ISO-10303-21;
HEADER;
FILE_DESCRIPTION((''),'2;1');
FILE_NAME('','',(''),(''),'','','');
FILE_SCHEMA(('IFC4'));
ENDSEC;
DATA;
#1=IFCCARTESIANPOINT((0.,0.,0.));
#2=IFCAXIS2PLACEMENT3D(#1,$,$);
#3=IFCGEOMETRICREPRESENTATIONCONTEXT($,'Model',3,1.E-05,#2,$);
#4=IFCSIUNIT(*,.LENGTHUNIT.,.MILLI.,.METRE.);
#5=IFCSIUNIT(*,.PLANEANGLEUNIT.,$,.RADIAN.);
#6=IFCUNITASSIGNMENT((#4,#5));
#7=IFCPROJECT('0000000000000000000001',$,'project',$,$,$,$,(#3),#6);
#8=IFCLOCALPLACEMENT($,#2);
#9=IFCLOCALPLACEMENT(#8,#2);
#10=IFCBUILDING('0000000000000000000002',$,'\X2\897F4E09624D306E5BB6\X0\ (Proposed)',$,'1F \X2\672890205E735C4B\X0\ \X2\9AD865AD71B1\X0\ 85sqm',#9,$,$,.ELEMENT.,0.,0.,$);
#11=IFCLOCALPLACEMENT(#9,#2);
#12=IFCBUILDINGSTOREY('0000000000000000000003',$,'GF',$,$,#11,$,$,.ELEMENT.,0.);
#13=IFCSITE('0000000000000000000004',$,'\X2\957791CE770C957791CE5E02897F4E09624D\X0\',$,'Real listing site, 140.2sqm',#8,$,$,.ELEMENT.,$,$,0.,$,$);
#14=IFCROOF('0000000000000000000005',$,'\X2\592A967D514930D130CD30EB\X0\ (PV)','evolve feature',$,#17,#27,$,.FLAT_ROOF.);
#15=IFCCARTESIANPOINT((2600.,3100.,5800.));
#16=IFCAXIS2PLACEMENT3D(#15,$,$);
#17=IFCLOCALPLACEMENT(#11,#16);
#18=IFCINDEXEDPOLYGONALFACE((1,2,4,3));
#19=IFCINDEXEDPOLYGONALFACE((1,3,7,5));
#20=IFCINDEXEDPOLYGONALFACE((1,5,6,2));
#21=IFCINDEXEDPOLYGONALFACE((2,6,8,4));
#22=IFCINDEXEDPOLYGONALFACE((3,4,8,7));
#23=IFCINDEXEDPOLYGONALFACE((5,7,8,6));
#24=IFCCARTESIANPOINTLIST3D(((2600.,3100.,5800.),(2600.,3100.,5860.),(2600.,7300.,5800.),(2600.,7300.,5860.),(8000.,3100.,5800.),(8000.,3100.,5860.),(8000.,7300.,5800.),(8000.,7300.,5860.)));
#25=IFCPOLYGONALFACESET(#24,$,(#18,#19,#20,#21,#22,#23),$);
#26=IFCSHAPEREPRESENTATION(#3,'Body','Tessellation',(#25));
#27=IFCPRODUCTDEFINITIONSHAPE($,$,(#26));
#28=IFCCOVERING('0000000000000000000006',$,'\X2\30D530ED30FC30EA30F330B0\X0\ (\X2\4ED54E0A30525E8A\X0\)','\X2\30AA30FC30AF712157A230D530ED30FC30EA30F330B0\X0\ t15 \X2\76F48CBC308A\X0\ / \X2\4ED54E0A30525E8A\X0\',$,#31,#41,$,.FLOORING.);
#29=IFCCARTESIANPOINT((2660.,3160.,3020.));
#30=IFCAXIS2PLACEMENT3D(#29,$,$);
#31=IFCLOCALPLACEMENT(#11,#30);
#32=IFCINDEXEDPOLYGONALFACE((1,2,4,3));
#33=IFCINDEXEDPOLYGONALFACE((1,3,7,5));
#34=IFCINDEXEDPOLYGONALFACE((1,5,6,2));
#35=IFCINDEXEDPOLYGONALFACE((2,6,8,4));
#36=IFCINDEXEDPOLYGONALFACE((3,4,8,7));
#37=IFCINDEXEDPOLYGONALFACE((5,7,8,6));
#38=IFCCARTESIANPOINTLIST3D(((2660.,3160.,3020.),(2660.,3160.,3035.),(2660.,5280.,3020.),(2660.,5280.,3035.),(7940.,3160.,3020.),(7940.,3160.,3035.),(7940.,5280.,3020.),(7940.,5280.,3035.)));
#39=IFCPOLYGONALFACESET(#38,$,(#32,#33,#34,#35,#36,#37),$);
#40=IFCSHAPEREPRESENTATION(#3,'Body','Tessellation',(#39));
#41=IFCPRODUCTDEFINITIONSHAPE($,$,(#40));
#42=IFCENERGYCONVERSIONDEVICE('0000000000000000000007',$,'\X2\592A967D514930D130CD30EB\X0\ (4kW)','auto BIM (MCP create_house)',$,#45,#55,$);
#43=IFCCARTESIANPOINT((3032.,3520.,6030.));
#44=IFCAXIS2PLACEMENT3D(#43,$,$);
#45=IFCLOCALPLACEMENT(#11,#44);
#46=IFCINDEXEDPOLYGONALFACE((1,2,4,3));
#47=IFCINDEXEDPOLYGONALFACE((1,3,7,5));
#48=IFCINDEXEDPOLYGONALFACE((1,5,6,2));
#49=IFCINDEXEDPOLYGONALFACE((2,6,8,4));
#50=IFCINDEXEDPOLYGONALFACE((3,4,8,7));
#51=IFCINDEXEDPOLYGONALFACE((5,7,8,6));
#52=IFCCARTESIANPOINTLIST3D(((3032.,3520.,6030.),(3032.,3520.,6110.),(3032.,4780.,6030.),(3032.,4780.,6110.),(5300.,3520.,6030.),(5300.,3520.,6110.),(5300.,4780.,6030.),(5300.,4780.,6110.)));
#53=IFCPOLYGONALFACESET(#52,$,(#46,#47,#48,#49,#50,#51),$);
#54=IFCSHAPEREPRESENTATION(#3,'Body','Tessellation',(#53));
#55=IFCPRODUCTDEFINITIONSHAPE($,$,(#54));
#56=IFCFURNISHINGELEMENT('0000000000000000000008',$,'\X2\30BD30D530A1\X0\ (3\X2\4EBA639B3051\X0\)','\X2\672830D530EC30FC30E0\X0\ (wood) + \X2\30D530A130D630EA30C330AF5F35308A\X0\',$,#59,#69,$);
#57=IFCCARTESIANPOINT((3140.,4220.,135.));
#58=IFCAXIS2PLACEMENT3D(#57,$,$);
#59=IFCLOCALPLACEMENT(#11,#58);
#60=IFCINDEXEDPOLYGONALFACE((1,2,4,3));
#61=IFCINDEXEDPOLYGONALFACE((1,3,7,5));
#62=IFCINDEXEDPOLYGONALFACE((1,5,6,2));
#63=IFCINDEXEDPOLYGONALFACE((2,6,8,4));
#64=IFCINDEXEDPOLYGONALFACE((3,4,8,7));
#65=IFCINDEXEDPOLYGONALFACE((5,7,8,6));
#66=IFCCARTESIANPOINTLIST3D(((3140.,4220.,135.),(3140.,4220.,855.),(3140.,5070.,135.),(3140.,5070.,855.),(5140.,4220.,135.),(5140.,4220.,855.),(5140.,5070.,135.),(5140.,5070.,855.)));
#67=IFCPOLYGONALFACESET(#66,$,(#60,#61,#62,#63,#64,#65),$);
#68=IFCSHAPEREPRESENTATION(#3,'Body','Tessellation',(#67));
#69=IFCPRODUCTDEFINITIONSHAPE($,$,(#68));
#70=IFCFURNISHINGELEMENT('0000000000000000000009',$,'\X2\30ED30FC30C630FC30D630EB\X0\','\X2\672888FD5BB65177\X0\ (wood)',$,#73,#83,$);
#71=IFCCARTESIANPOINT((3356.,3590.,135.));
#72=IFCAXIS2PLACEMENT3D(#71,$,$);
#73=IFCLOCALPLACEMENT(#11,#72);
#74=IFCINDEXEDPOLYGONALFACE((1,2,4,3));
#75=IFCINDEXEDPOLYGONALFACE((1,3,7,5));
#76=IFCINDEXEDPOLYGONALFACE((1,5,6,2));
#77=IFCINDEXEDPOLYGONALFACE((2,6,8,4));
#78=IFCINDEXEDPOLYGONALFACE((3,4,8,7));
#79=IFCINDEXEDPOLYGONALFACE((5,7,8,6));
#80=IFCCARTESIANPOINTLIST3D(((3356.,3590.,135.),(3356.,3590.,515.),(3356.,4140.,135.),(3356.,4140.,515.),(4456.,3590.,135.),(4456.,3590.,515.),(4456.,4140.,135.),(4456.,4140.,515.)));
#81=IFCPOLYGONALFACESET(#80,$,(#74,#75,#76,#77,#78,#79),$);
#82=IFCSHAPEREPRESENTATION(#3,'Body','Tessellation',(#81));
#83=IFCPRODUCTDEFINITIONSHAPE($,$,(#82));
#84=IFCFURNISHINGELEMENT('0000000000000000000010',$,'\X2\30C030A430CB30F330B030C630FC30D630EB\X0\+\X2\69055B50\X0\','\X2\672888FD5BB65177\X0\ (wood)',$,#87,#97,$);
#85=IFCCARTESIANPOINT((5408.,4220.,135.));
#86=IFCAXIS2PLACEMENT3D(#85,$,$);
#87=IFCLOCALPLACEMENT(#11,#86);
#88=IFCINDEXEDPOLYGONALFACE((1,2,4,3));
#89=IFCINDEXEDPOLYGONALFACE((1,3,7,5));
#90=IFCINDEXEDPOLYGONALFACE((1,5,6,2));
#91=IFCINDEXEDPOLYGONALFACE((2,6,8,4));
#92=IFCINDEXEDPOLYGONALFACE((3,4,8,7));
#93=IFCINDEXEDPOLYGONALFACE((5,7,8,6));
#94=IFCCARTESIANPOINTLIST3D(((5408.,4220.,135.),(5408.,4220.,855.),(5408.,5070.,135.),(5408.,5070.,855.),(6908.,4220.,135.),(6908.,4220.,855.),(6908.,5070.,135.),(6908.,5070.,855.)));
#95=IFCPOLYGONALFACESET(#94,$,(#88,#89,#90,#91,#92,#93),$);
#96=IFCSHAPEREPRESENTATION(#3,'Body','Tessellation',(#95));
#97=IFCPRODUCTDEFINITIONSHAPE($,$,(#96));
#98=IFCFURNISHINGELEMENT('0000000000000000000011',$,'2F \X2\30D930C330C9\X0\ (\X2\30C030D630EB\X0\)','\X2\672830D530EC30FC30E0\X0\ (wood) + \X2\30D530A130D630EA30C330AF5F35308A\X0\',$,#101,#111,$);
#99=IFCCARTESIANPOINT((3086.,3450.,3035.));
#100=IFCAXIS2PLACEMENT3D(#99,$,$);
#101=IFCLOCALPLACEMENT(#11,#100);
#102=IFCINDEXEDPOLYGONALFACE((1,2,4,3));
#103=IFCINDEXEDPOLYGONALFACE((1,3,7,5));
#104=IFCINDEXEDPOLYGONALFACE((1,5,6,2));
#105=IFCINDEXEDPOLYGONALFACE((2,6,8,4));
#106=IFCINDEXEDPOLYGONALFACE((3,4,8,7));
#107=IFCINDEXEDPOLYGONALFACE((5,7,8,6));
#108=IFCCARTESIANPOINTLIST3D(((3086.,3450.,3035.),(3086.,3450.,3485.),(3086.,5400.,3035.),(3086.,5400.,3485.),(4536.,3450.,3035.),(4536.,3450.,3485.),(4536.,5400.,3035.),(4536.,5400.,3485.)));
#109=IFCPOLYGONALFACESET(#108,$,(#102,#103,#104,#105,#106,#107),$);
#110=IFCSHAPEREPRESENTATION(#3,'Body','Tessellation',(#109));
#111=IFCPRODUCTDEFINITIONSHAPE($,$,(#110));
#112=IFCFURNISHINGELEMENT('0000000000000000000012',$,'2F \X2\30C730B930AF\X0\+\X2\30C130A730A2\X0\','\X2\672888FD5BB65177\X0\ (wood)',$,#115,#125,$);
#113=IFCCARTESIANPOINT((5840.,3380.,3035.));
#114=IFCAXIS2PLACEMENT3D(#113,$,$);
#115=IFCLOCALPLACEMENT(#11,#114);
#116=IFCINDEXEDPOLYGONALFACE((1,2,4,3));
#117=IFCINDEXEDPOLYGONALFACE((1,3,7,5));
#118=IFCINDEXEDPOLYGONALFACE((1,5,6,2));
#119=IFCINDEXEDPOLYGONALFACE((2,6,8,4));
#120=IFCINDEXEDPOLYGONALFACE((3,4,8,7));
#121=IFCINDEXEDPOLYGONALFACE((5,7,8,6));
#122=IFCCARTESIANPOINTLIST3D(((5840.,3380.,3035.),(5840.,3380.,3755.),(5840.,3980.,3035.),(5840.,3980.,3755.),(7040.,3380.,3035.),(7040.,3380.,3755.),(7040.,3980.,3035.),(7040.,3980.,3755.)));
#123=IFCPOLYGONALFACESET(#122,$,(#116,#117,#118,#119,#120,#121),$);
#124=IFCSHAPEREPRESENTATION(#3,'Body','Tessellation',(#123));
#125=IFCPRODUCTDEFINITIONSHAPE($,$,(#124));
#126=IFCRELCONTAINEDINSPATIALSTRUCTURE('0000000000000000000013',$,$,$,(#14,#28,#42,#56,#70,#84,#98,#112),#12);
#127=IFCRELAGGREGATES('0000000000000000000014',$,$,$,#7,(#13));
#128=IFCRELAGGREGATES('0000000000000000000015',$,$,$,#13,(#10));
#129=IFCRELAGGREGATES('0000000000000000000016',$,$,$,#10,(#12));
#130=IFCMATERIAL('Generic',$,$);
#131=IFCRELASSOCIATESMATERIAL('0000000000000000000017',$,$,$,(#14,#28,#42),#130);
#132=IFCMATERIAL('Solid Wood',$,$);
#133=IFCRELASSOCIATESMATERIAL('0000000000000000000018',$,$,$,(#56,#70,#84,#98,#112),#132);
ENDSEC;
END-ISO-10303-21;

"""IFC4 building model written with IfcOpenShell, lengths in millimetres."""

from ifc_helpers import new_model, si_unit, frame, frame_2d, origin, place, context, project, spatial, rectangle, extrude, material, element, save


model = new_model("IFC4")

# Units and contexts
model_context = context("Model", 3, precision=1e-05, world=origin())
ifc_project = project(units=[si_unit("LENGTHUNIT", "METRE", prefix="MILLI"), si_unit("PLANEANGLEUNIT", "RADIAN")], contexts=[model_context])

# Site, building, storey
site_placement = place(None, origin())
site = spatial("IfcSite", under=ifc_project, at=site_placement, Name="長野県長野市西三才", ObjectType="Real listing site, 140.2sqm", CompositionType="ELEMENT", RefElevation=0.0)
building_placement = place(site_placement, origin())
building = spatial("IfcBuilding", under=site, at=building_placement, Name="西三才の家 (Proposed)", ObjectType="1F 木造平屋 高断熱 85sqm", CompositionType="ELEMENT", ElevationOfRefHeight=0.0, ElevationOfTerrain=0.0)
storey_placement = place(building_placement, origin())
storey = spatial("IfcBuildingStorey", under=building, at=storey_placement, Name="GF", CompositionType="ELEMENT", Elevation=0.0)

# Shared definitions
ifc_material_1 = material(Name="Solid Wood")

# Roof
ifc_material_2 = material(Name="Generic")
roof_1_placement = place(storey_placement, frame((2600.0, 3100.0, 5800.0)))
element("IfcRoof", 1, at=roof_1_placement, inside=storey, material=ifc_material_2, Name="太陽光パネル (PV)", Description="evolve feature", PredefinedType="FLAT_ROOF", context=model_context, shape_type="SweptSolid", body=[
    extrude(rectangle(XDim=5400.0, YDim=4200.0, at=frame_2d((2700.0, 2100.0))), frame((2600.0, 3100.0, 5800.0)), (0.0, 0.0, 1.0), 60.0),
])

# Covering
covering_placement = place(storey_placement, frame((2660.0, 3160.0, 3020.0)))
element("IfcCovering", 2, at=covering_placement, inside=storey, material=ifc_material_2, Name="フローリング (仕上げ床)", Description="オーク無垢フローリング t15 直貼り / 仕上げ床", PredefinedType="FLOORING", context=model_context, shape_type="SweptSolid", body=[
    extrude(rectangle(XDim=5280.0, YDim=2120.0, at=frame_2d((2640.0, 1060.0))), frame((2660.0, 3160.0, 3020.0)), (0.0, 0.0, 1.0), 15.0),
])

# Energy conversion device
energy_conversion_device_placement = place(storey_placement, frame((3032.0, 3520.0, 6030.0)))
element("IfcEnergyConversionDevice", 3, at=energy_conversion_device_placement, inside=storey, material=ifc_material_2, Name="太陽光パネル (4kW)", Description="auto BIM (MCP create_house)", context=model_context, shape_type="SweptSolid", body=[
    extrude(rectangle(XDim=2268.0, YDim=1260.0, at=frame_2d((1134.0, 630.0))), frame((3032.0, 3520.0, 6030.0)), (0.0, 0.0, 1.0), 80.0),
])

# Furnishing elements
furnishing_1_placement = place(storey_placement, frame((3140.0, 4220.0, 135.0)))
element("IfcFurnishingElement", 4, at=furnishing_1_placement, inside=storey, material=ifc_material_1, Name="ソファ (3人掛け)", Description="木フレーム (wood) + ファブリック張り", context=model_context, shape_type="SweptSolid", body=[
    extrude(rectangle(XDim=2000.0, YDim=850.0, at=frame_2d((1000.0, 425.0))), frame((3140.0, 4220.0, 135.0)), (0.0, 0.0, 1.0), 720.0),
])
furnishing_2_placement = place(storey_placement, frame((3356.0, 3590.0, 135.0)))
element("IfcFurnishingElement", 5, at=furnishing_2_placement, inside=storey, material=ifc_material_1, Name="ローテーブル", Description="木製家具 (wood)", context=model_context, shape_type="SweptSolid", body=[
    extrude(rectangle(XDim=1100.0, YDim=550.0, at=frame_2d((550.0, 275.0))), frame((3356.0, 3590.0, 135.0)), (0.0, 0.0, 1.0), 380.0),
])
furnishing_3_placement = place(storey_placement, frame((5408.0, 4220.0, 135.0)))
element("IfcFurnishingElement", 6, at=furnishing_3_placement, inside=storey, material=ifc_material_1, Name="ダイニングテーブル+椅子", Description="木製家具 (wood)", context=model_context, shape_type="SweptSolid", body=[
    extrude(rectangle(XDim=1500.0, YDim=850.0, at=frame_2d((750.0, 425.0))), frame((5408.0, 4220.0, 135.0)), (0.0, 0.0, 1.0), 720.0),
])
furnishing_4_placement = place(storey_placement, frame((3086.0, 3450.0, 3035.0)))
element("IfcFurnishingElement", 7, at=furnishing_4_placement, inside=storey, material=ifc_material_1, Name="2F ベッド (ダブル)", Description="木フレーム (wood) + ファブリック張り", context=model_context, shape_type="SweptSolid", body=[
    extrude(rectangle(XDim=1450.0, YDim=1950.0, at=frame_2d((725.0, 975.0))), frame((3086.0, 3450.0, 3035.0)), (0.0, 0.0, 1.0), 450.0),
])
furnishing_5_placement = place(storey_placement, frame((5840.0, 3380.0, 3035.0)))
element("IfcFurnishingElement", 8, at=furnishing_5_placement, inside=storey, material=ifc_material_1, Name="2F デスク+チェア", Description="木製家具 (wood)", context=model_context, shape_type="SweptSolid", body=[
    extrude(rectangle(XDim=1200.0, YDim=600.0, at=frame_2d((600.0, 300.0))), frame((5840.0, 3380.0, 3035.0)), (0.0, 0.0, 1.0), 720.0),
])

save(model, "model.ifc")
